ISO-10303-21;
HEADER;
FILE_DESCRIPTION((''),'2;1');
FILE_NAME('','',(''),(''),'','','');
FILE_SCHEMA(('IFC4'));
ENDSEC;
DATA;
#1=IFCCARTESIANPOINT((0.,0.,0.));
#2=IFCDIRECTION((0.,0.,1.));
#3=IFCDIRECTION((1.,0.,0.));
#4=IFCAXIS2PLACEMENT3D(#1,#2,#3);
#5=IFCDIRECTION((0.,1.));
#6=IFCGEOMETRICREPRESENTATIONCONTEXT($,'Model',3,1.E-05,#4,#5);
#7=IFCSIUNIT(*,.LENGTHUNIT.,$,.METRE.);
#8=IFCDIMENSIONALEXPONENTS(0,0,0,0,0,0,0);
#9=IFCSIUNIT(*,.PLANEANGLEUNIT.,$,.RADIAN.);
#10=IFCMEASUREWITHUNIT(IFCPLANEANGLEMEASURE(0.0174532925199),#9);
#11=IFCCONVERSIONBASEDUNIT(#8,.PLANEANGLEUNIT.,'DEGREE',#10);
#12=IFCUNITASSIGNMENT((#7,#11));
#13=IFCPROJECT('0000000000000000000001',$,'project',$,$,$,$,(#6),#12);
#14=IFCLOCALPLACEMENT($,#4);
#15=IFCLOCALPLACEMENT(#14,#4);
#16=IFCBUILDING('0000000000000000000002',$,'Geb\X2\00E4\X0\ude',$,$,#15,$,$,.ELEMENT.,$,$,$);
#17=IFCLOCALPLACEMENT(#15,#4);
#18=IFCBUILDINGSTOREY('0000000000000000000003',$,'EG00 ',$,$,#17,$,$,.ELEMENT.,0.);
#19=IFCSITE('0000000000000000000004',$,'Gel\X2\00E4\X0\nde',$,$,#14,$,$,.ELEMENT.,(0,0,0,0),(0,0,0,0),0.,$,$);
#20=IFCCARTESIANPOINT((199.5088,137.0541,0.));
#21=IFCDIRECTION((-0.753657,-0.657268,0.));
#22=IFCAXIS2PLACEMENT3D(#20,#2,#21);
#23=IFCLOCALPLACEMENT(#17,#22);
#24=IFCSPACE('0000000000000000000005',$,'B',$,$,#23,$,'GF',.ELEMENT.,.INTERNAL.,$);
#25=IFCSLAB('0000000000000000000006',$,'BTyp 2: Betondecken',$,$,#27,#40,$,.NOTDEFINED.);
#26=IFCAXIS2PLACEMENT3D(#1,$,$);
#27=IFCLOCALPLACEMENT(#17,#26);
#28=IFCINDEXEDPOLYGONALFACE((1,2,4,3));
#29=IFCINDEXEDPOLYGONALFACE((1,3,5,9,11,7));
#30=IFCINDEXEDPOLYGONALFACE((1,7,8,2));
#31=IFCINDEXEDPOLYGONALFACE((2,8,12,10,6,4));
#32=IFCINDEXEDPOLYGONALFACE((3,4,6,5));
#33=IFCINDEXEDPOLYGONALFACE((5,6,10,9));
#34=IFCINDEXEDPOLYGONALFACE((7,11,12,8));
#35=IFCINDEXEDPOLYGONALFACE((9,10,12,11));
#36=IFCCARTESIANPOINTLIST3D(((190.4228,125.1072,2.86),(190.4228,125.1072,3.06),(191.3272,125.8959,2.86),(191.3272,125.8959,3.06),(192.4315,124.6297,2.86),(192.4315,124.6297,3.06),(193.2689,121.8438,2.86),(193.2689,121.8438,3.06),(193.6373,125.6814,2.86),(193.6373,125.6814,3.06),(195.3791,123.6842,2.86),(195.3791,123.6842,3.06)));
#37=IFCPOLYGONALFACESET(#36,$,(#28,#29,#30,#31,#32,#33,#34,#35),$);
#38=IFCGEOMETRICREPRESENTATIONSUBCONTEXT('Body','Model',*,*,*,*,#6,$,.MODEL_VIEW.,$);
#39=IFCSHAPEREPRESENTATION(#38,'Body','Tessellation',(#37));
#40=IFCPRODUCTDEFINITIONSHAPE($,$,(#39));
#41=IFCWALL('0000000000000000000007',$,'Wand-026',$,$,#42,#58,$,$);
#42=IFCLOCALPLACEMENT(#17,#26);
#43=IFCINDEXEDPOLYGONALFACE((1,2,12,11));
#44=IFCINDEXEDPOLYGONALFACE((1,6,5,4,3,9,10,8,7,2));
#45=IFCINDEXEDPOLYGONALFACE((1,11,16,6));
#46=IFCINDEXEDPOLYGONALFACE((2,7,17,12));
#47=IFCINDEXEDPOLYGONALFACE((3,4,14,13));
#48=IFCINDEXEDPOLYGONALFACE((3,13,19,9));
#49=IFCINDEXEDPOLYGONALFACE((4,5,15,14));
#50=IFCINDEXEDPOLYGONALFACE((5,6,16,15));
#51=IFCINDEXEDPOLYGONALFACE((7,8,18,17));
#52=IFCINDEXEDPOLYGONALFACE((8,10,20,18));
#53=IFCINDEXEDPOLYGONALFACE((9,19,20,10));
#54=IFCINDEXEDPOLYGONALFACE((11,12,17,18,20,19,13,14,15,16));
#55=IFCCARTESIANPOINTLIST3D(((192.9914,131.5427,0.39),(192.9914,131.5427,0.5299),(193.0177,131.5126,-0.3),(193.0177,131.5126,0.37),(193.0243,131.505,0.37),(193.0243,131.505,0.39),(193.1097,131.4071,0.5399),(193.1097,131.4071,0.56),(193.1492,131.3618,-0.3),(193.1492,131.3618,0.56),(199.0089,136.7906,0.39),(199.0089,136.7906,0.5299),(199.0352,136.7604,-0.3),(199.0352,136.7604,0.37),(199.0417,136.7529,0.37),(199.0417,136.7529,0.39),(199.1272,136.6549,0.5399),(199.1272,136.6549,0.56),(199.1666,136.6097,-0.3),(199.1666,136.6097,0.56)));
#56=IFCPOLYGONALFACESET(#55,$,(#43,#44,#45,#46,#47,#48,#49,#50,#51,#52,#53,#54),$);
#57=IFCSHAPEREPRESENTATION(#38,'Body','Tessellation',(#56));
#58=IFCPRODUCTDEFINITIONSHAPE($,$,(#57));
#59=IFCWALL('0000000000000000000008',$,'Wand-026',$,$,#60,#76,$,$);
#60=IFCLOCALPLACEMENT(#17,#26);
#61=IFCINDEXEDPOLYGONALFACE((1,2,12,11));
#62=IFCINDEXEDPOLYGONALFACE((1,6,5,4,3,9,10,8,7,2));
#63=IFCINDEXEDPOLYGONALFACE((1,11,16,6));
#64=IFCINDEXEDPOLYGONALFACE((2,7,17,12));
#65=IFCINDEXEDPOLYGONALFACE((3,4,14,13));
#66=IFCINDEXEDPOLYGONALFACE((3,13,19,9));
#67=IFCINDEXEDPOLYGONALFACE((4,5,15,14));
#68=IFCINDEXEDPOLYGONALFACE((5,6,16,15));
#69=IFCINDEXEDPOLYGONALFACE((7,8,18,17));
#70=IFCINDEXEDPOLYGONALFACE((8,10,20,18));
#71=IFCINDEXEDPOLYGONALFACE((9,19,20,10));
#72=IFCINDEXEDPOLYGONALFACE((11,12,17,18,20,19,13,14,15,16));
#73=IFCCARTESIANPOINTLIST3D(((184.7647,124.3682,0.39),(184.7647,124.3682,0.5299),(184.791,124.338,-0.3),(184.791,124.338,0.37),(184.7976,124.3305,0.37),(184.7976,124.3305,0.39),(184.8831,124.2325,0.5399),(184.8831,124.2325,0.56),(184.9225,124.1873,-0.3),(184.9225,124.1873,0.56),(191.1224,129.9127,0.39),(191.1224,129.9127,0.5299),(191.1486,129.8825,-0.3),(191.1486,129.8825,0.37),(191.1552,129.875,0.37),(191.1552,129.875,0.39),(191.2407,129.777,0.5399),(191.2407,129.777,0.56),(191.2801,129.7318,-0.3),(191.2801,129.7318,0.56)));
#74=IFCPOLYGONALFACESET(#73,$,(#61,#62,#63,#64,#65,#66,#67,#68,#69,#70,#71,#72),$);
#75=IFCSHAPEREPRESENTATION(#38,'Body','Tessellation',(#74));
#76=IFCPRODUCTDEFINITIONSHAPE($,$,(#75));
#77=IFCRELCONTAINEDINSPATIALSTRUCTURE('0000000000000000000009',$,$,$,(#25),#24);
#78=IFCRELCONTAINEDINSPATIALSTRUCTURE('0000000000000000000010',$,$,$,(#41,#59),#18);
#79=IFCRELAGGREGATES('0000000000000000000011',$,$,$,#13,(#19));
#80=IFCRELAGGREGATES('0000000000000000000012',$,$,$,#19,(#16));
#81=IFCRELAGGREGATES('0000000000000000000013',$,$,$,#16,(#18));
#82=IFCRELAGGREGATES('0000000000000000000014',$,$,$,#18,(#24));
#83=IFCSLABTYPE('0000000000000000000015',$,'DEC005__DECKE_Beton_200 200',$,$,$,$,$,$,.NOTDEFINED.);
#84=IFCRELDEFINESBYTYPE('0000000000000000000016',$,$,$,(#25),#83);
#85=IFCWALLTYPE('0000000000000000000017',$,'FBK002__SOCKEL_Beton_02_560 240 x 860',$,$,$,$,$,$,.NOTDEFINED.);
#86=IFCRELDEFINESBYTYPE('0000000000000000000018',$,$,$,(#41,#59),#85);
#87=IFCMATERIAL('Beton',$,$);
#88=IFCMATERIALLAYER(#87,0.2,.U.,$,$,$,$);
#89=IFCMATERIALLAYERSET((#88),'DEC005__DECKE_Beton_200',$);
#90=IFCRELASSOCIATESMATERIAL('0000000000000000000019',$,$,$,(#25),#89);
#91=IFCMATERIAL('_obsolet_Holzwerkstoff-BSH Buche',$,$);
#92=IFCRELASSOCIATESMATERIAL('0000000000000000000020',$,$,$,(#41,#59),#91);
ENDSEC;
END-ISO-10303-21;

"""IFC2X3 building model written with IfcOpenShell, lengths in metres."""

from ifc_helpers import new_model, entity, si_unit, converted_unit, direction, frame, origin_with_axes, place, context, subcontext, project, spatial, polyline, outline, extrude, material, layer, layer_set, layer_usage, type_object, element, save


model = new_model("IFC2X3")

# Units and contexts
model_context = context("Model", 3, precision=1e-05, world=origin_with_axes(), true_north=direction((0.0, 1.0)))
body_context = subcontext(model_context, "Body", "Model", "MODEL_VIEW")
ifc_project = project(units=[si_unit("LENGTHUNIT", "METRE"), converted_unit("PLANEANGLEUNIT", "DEGREE", entity("IfcPlaneAngleMeasure", 0.0174532925199), si_unit("PLANEANGLEUNIT", "RADIAN"), dimensions=[0, 0, 0, 0, 0, 0, 0])], contexts=[model_context])

# Site, building, storey, space
site_placement = place(None, origin_with_axes())
site = spatial("IfcSite", under=ifc_project, at=site_placement, Name="Gelände", CompositionType="ELEMENT", RefLatitude=(0, 0, 0, 0), RefLongitude=(0, 0, 0, 0), RefElevation=0.0)
building_placement = place(site_placement, origin_with_axes())
building = spatial("IfcBuilding", under=site, at=building_placement, Name="Gebäude", CompositionType="ELEMENT")
storey_placement = place(building_placement, origin_with_axes())
storey = spatial("IfcBuildingStorey", under=building, at=storey_placement, Name="EG00 ", CompositionType="ELEMENT", Elevation=0.0)
space_placement = place(storey_placement, frame((199.5088, 137.0541, 0.0), z_axis=(0.0, 0.0, 1.0), x_axis=(-0.753657, -0.657268, 0.0)))
space = spatial("IfcSpace", under=storey, at=space_placement, Name="B", LongName="GF", CompositionType="ELEMENT", InteriorOrExteriorSpace="INTERNAL")

# Slab
ifc_material_1 = material(Name="Beton")
ifc_layer_1 = layer(ifc_material_1, 0.2, ventilated="UNKNOWN")
ifc_layer_set_1 = layer_set([ifc_layer_1], Name="DEC005__DECKE_Beton_200")
ifc_layer_usage_1 = layer_usage(ifc_layer_set_1, "AXIS3", "NEGATIVE", 0.2)
slab_type_1 = type_object("IfcSlabType", Name="DEC005__DECKE_Beton_200 200", PredefinedType="NOTDEFINED")
slab_1_placement = place(space_placement, frame((11.9, 4.712, 3.06), z_axis=(0.0, 0.0, 1.0), x_axis=(-0.753657, 0.657268, 0.0)))
element("IfcSlab", 1, at=slab_1_placement, inside=space, type_object=slab_type_1, material=ifc_layer_usage_1, Name="BTyp 2: Betondecken", PredefinedType="NOTDEFINED", context=body_context, shape_type="SweptSolid", body=[
    extrude(outline(polyline([(0.0, 0.0), (-1.2059, -1.0516), (-2.3101, 0.2146), (-3.2145, -0.5741), (-0.3685, -3.8375), (1.7418, -1.9972), (0.0, 0.0)])), frame((0.0, 0.0, -0.2), z_axis=(0.0, 0.0, 1.0), x_axis=(1.0, 0.0, 0.0)), (0.0, 0.0, 1.0), 0.2),
])

# Walls
ifc_material_2 = material(Name="_obsolet_Holzwerkstoff-BSH Buche")
wall_type_1 = type_object("IfcWallType", Name="FBK002__SOCKEL_Beton_02_560 240 x 860", PredefinedType="NOTDEFINED")
wall_1_placement = place(storey_placement, frame((199.1272, 136.6549, -0.3), z_axis=(0.0, 0.0, 1.0), x_axis=(-0.753657, -0.657268, 0.0)))
element("IfcWall", 2, at=wall_1_placement, inside=storey, type_object=wall_type_1, material=ifc_material_2, Name="Wand-026", context=body_context, shape_type="SweptSolid", body=[
    extrude(outline(polyline([(0.0, 0.8399), (-0.18, 0.8299), (-0.18, 0.69), (-0.13, 0.69), (-0.13, 0.67), (-0.14, 0.67), (-0.14, 0.0), (0.06, 0.0), (0.06, 0.86), (0.0, 0.86), (0.0, 0.8399)])), frame((0.0, 0.0, 0.0), z_axis=(1.0, 0.0, 0.0), x_axis=(0.0, 1.0, 0.0)), (0.0, 0.0, 1.0), 7.9843),
])
wall_2_placement = place(storey_placement, frame((191.2407, 129.777, -0.3), z_axis=(0.0, 0.0, 1.0), x_axis=(-0.753657, -0.657268, 0.0)))
element("IfcWall", 3, at=wall_2_placement, inside=storey, type_object=wall_type_1, material=ifc_material_2, Name="Wand-026", context=body_context, shape_type="SweptSolid", body=[
    extrude(outline(polyline([(0.0, 0.8399), (-0.18, 0.8299), (-0.18, 0.69), (-0.13, 0.69), (-0.13, 0.67), (-0.14, 0.67), (-0.14, 0.0), (0.06, 0.0), (0.06, 0.86), (0.0, 0.86), (0.0, 0.8399)])), frame((0.0, 0.0, 0.0), z_axis=(1.0, 0.0, 0.0), x_axis=(0.0, 1.0, 0.0)), (0.0, 0.0, 1.0), 8.4357),
])

save(model, "model.ifc")
